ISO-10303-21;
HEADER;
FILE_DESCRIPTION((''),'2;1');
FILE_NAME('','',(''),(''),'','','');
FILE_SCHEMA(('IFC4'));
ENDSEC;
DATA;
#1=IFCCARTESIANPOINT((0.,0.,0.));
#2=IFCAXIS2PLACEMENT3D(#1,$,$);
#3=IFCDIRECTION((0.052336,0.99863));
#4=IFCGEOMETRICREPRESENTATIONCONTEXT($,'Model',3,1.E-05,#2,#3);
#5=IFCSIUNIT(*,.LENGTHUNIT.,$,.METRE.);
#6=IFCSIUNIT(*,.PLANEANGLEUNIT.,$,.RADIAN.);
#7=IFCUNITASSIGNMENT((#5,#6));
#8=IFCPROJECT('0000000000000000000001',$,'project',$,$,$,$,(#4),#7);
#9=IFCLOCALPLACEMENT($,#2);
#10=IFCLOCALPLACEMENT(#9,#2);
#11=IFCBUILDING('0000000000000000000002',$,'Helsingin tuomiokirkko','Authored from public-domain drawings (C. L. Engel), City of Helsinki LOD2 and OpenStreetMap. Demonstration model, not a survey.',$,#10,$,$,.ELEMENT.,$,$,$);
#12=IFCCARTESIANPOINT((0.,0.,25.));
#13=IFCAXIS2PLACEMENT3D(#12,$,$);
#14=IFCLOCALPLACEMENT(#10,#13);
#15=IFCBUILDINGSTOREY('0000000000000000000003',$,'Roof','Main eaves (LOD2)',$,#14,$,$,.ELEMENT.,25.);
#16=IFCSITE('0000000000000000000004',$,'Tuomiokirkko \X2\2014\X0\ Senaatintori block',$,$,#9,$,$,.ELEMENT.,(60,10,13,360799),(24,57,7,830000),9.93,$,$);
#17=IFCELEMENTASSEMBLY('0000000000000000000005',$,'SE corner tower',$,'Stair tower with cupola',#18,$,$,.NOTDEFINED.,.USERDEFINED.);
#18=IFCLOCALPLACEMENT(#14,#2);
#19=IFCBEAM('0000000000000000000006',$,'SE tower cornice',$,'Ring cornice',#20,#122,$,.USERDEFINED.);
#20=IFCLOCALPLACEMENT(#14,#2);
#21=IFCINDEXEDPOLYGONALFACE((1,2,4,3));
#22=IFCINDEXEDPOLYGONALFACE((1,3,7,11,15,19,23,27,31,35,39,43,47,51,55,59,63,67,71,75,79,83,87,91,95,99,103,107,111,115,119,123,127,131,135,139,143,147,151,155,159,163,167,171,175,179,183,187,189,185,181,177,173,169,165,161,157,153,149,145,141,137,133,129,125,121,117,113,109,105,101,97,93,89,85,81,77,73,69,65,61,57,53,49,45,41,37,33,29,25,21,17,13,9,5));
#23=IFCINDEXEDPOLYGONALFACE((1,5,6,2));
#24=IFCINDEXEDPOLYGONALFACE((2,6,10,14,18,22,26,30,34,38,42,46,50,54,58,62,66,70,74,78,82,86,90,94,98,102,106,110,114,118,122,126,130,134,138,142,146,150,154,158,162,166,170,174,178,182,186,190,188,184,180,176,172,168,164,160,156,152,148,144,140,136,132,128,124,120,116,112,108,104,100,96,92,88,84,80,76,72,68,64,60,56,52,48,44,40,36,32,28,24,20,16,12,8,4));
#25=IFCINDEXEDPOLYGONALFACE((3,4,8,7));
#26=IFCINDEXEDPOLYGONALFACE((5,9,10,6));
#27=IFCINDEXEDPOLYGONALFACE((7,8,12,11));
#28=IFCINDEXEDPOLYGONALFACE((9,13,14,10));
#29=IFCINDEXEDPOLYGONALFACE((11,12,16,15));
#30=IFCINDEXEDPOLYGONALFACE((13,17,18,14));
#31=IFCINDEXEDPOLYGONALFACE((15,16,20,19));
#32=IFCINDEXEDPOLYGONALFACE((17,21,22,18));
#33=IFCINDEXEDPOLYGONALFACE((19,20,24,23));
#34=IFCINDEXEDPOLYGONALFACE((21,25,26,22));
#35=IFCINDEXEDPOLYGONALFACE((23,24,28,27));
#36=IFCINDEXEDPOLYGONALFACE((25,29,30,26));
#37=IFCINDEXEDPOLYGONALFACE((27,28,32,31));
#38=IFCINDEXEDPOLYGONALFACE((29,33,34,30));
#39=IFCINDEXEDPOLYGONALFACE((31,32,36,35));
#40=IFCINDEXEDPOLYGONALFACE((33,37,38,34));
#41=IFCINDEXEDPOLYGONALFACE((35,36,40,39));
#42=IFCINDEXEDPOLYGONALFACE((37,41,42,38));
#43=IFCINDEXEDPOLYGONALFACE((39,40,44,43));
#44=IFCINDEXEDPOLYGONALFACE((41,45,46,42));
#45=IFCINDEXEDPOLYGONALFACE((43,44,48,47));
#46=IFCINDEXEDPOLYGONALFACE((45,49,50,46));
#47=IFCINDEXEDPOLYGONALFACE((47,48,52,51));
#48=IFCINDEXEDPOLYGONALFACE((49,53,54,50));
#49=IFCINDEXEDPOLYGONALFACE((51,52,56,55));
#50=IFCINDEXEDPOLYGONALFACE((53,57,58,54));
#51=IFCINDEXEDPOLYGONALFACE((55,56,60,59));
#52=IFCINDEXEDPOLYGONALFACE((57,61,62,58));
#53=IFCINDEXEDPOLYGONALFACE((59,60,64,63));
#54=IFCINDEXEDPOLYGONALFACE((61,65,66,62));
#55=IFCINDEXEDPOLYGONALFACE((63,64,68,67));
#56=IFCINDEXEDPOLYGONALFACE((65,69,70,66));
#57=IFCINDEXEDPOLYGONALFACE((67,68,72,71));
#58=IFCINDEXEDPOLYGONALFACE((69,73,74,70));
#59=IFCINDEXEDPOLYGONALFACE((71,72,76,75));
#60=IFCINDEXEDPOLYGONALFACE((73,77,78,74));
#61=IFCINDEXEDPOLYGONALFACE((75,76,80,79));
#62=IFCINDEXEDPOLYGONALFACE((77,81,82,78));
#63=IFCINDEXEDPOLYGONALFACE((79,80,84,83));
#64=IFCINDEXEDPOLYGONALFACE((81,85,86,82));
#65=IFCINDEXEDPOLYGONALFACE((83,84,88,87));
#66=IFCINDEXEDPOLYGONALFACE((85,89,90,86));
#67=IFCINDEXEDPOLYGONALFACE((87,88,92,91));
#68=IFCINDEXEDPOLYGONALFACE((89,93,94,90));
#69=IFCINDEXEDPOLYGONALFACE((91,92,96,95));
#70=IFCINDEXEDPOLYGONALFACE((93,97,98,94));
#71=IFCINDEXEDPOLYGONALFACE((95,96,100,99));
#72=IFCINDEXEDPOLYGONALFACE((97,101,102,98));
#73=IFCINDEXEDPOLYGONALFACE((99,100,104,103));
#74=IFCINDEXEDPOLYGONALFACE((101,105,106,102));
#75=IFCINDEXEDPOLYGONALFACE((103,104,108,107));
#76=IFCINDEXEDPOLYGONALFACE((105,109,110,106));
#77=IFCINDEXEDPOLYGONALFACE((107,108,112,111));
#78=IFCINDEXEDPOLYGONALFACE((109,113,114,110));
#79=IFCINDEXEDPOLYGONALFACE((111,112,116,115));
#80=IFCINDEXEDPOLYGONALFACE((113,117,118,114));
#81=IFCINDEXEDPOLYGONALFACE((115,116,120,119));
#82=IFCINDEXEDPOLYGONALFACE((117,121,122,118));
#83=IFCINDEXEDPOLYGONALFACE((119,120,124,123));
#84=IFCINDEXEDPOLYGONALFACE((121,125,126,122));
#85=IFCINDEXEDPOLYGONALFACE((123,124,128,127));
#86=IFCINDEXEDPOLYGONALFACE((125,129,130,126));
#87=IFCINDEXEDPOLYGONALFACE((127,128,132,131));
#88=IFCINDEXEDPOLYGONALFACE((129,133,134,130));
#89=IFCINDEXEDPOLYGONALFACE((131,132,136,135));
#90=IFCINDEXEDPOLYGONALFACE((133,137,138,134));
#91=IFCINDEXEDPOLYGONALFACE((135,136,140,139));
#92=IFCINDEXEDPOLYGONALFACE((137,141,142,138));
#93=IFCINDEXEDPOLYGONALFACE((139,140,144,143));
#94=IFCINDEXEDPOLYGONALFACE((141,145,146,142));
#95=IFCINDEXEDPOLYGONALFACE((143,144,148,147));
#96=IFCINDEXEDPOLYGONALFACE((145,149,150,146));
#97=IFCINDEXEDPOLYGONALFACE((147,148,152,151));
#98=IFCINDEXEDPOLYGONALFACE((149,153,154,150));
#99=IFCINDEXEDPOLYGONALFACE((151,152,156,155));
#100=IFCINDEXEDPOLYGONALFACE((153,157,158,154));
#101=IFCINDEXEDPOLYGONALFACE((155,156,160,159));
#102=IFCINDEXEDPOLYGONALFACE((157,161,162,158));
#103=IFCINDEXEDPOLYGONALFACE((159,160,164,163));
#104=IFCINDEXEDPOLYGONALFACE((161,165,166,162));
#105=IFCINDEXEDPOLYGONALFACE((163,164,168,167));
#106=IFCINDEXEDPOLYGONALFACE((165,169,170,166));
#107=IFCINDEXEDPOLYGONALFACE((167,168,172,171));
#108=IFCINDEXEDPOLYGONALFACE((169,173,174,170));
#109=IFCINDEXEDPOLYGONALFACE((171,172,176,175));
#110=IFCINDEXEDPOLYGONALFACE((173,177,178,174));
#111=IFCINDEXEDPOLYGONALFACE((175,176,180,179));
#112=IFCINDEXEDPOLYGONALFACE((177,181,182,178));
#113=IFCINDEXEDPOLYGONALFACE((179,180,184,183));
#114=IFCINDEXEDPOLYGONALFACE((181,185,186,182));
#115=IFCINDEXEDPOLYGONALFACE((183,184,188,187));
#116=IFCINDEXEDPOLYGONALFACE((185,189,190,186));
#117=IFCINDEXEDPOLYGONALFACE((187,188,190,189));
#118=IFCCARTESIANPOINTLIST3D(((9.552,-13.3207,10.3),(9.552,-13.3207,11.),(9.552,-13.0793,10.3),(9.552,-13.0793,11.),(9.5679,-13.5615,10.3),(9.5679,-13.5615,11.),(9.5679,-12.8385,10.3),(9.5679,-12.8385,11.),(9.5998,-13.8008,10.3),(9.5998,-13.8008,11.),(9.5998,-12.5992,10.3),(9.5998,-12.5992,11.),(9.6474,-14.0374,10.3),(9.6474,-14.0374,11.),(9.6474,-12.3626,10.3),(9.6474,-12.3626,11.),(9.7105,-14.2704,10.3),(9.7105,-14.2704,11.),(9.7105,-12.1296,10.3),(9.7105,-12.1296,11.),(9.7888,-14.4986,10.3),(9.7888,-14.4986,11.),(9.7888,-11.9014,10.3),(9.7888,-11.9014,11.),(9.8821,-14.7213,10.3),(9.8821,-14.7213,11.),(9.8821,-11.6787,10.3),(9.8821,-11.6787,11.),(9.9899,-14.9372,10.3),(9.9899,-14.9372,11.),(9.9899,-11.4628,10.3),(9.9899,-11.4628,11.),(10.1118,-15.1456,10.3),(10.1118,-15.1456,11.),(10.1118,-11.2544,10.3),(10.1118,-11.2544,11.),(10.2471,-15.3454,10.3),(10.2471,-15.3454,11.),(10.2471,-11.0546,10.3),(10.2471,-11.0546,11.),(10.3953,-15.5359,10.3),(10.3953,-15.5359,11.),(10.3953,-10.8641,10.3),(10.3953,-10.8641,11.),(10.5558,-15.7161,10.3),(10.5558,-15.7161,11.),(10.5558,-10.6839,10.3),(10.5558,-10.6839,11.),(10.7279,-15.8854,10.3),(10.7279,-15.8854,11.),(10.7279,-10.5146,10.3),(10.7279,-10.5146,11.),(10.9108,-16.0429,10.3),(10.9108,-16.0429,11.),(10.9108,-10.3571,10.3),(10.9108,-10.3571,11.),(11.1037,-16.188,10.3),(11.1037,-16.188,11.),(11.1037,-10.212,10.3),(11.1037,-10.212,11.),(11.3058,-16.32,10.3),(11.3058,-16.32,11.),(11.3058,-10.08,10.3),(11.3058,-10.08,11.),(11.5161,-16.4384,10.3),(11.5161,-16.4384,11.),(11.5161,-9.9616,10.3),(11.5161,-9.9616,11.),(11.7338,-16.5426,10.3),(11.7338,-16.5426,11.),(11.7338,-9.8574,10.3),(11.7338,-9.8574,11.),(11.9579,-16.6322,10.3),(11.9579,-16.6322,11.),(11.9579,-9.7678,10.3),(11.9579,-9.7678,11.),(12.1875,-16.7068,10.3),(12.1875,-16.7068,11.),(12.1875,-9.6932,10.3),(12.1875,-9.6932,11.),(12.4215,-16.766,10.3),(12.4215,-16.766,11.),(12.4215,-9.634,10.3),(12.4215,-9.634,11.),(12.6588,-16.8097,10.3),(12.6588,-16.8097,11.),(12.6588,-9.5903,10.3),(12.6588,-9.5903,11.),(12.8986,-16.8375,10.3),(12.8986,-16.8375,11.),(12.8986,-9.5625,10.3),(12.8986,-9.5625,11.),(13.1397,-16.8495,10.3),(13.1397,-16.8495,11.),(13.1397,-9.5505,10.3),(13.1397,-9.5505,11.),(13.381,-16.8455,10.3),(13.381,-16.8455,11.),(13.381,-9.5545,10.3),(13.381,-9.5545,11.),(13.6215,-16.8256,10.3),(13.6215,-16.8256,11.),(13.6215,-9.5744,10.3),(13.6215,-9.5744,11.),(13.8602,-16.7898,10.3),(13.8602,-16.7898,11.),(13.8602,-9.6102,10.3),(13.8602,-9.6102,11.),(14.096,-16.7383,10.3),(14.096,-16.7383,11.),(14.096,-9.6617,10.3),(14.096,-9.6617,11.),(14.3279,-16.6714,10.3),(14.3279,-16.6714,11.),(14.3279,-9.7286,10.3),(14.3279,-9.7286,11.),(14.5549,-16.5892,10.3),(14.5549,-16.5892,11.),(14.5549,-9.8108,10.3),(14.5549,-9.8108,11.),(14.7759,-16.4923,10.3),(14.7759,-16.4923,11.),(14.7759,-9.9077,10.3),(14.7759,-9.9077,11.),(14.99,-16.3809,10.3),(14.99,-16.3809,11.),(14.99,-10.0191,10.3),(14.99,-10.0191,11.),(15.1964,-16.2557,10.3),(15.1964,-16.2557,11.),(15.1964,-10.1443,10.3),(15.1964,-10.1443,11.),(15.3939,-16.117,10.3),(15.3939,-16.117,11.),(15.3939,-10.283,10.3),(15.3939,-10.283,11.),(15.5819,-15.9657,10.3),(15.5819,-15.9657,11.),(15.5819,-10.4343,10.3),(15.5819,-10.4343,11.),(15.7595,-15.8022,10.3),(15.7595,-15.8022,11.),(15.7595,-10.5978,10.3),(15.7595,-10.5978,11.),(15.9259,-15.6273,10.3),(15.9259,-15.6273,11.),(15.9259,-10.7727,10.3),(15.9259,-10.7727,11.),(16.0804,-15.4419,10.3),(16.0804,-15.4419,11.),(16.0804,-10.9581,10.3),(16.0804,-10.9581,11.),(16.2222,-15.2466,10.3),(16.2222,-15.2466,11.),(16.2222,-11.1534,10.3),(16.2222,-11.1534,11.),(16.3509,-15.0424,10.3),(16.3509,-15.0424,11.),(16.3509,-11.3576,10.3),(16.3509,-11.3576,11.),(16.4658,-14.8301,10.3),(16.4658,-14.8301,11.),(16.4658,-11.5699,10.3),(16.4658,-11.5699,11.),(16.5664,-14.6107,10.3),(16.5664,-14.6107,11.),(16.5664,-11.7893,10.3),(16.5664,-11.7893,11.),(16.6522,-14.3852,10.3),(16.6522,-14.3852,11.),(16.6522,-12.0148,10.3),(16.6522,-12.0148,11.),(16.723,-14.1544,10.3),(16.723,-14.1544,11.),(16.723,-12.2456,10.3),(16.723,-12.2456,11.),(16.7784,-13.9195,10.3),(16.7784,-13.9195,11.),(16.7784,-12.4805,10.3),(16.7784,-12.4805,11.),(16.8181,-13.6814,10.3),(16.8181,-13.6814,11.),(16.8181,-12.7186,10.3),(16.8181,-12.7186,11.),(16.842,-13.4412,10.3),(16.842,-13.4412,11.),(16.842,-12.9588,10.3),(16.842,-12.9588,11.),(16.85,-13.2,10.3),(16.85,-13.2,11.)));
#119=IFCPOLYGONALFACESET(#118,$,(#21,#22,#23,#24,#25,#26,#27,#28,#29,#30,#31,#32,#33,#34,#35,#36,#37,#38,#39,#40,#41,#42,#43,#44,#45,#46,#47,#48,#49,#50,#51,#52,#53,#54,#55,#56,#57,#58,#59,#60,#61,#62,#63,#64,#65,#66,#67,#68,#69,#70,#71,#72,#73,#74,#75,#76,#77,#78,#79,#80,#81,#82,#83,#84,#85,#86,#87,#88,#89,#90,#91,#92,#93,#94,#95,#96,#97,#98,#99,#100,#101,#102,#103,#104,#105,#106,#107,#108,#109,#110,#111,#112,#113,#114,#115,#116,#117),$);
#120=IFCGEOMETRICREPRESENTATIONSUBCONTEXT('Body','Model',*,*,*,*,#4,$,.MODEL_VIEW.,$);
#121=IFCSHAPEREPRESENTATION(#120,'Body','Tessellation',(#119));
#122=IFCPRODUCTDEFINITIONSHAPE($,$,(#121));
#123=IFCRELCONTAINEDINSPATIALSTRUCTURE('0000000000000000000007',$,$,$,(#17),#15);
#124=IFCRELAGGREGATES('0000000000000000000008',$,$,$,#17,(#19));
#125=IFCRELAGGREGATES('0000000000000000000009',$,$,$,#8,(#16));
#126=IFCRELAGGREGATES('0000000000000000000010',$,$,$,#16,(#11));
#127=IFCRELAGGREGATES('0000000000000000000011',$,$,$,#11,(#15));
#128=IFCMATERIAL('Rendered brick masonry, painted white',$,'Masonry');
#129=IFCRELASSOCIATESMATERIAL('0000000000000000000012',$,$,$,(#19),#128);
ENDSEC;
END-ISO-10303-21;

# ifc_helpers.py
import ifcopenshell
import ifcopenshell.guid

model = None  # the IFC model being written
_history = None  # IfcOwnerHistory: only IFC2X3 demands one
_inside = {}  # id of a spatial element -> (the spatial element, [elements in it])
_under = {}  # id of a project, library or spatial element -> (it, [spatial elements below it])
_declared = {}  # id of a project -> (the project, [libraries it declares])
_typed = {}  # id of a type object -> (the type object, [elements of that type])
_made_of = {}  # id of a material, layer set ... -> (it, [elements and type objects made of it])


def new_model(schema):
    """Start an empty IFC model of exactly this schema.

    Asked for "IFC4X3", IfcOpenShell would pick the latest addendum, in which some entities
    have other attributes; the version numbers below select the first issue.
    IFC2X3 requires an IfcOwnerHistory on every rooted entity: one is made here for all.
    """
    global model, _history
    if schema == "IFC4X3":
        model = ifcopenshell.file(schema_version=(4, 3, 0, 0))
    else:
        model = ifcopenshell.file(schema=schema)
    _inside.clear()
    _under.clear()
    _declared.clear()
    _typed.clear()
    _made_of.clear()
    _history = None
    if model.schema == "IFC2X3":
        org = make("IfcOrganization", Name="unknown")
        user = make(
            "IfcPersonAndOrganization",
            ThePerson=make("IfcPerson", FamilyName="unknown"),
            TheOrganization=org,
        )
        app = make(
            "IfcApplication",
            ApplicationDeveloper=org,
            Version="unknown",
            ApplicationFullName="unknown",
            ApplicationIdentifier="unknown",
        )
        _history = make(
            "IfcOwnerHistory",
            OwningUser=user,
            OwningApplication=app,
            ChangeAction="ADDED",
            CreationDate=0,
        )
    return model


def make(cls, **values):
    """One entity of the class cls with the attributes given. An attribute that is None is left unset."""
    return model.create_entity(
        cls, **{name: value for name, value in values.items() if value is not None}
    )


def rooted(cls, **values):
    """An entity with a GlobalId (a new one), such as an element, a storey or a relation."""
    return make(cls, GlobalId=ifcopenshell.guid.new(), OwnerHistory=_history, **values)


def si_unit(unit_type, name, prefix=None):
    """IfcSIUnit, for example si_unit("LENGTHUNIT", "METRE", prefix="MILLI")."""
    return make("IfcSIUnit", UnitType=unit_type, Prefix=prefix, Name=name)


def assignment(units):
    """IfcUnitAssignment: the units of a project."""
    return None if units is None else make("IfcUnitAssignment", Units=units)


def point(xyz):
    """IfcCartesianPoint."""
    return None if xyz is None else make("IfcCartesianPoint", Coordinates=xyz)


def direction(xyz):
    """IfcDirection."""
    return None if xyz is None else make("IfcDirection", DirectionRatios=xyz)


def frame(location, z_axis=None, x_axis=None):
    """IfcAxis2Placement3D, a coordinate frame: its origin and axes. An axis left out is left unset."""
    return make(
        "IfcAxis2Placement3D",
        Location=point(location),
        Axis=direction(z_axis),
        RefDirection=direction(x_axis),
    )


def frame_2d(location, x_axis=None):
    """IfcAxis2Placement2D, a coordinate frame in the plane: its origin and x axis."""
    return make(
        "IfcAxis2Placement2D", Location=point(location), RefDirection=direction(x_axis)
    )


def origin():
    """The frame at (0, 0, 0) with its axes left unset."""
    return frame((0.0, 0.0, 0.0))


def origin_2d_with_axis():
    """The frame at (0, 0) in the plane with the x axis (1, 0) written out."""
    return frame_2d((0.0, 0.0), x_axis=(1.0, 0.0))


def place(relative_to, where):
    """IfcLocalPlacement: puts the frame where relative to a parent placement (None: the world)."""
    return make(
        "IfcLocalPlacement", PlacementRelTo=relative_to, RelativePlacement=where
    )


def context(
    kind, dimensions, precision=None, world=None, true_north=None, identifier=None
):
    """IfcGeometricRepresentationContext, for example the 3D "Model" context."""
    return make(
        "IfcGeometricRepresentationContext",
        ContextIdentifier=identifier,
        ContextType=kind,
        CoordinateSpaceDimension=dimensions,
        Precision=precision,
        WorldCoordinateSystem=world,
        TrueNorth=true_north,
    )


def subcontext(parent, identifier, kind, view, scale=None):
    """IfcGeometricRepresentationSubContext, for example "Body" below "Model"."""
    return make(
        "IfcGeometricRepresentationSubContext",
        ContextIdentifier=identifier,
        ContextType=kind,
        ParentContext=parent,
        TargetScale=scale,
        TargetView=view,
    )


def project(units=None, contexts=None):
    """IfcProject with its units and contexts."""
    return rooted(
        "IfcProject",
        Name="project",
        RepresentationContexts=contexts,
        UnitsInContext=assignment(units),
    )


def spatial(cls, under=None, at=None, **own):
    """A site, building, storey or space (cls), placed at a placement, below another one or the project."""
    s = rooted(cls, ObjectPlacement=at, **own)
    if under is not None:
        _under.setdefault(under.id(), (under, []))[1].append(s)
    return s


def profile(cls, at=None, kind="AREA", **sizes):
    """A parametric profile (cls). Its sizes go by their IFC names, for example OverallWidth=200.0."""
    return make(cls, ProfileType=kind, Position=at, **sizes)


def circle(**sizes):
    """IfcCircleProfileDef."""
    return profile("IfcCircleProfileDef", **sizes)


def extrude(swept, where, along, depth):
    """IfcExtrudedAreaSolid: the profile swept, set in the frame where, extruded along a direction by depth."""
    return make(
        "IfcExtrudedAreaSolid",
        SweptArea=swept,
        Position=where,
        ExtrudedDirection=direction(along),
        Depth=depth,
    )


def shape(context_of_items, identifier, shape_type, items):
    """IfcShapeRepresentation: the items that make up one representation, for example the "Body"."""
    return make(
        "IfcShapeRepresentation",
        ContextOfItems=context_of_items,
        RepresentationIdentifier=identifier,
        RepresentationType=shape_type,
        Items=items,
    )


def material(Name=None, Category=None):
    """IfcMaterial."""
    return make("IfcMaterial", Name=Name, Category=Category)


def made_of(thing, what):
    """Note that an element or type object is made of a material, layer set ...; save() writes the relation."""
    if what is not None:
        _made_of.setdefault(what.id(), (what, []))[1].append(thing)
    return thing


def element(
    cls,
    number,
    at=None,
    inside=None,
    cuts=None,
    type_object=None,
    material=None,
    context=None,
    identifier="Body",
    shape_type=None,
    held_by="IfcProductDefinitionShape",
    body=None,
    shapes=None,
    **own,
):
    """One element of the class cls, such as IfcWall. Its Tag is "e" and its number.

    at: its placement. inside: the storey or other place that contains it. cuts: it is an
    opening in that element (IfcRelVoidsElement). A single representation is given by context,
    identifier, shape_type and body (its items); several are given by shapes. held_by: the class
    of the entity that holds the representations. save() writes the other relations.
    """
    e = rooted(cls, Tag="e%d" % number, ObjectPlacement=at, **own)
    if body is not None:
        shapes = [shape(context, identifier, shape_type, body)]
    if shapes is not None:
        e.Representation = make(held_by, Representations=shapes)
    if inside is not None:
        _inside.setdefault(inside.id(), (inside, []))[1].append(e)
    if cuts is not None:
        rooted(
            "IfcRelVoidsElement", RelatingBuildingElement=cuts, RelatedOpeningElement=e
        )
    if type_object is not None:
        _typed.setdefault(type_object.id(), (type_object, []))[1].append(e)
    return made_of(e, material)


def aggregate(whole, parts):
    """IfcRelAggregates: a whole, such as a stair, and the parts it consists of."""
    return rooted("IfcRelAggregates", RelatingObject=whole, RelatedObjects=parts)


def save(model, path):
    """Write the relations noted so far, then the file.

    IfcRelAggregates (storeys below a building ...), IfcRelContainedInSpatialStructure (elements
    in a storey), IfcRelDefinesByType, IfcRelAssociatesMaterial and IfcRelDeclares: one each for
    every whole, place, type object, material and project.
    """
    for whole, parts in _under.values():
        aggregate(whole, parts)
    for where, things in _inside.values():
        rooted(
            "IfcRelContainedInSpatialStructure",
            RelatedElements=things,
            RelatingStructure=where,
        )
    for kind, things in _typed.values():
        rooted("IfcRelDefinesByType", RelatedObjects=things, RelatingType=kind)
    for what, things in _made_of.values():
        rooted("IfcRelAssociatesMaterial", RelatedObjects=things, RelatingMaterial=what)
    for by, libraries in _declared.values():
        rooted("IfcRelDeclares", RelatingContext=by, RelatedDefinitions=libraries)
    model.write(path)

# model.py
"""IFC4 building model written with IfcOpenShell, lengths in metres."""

from ifc_helpers import new_model, si_unit, direction, frame, origin, origin_2d_with_axis, place, context, subcontext, project, spatial, circle, extrude, material, element, aggregate, save


model = new_model("IFC4")

# Units and contexts
model_context = context("Model", 3, precision=1e-05, world=origin(), true_north=direction((0.052336, 0.99863)))
body_context = subcontext(model_context, "Body", "Model", "MODEL_VIEW")
ifc_project = project(units=[si_unit("LENGTHUNIT", "METRE"), si_unit("PLANEANGLEUNIT", "RADIAN")], contexts=[model_context])

# Site, building, storey
site_placement = place(None, origin())
site = spatial("IfcSite", under=ifc_project, at=site_placement, Name="Tuomiokirkko — Senaatintori block", CompositionType="ELEMENT", RefLatitude=(60, 10, 13, 360799), RefLongitude=(24, 57, 7, 830000), RefElevation=9.93)
building_placement = place(site_placement, origin())
building = spatial("IfcBuilding", under=site, at=building_placement, Name="Helsingin tuomiokirkko", Description="Authored from public-domain drawings (C. L. Engel), City of Helsinki LOD2 and OpenStreetMap. Demonstration model, not a survey.", CompositionType="ELEMENT")
storey_placement = place(building_placement, frame((0.0, 0.0, 25.0)))
storey = spatial("IfcBuildingStorey", under=building, at=storey_placement, Name="Roof", Description="Main eaves (LOD2)", CompositionType="ELEMENT", Elevation=25.0)

# Element assembly
assembly_1_placement = place(building_placement, origin())
assembly_1 = element("IfcElementAssembly", 1, at=assembly_1_placement, inside=storey, Name="SE corner tower", ObjectType="Stair tower with cupola", AssemblyPlace="NOTDEFINED", PredefinedType="USERDEFINED")

# Beam
ifc_material_1 = material(Name="Rendered brick masonry, painted white", Category="Masonry")
beam_1_placement = place(building_placement, origin())
beam_1 = element("IfcBeam", 2, at=beam_1_placement, material=ifc_material_1, Name="SE tower cornice", ObjectType="Ring cornice", PredefinedType="USERDEFINED", context=body_context, shape_type="SweptSolid", body=[
    extrude(circle(Radius=3.65, at=origin_2d_with_axis()), frame((13.2, -13.2, 35.3)), (0.0, 0.0, 1.0), 0.7),
])

aggregate(assembly_1, [beam_1])

save(model, "model.ifc")
